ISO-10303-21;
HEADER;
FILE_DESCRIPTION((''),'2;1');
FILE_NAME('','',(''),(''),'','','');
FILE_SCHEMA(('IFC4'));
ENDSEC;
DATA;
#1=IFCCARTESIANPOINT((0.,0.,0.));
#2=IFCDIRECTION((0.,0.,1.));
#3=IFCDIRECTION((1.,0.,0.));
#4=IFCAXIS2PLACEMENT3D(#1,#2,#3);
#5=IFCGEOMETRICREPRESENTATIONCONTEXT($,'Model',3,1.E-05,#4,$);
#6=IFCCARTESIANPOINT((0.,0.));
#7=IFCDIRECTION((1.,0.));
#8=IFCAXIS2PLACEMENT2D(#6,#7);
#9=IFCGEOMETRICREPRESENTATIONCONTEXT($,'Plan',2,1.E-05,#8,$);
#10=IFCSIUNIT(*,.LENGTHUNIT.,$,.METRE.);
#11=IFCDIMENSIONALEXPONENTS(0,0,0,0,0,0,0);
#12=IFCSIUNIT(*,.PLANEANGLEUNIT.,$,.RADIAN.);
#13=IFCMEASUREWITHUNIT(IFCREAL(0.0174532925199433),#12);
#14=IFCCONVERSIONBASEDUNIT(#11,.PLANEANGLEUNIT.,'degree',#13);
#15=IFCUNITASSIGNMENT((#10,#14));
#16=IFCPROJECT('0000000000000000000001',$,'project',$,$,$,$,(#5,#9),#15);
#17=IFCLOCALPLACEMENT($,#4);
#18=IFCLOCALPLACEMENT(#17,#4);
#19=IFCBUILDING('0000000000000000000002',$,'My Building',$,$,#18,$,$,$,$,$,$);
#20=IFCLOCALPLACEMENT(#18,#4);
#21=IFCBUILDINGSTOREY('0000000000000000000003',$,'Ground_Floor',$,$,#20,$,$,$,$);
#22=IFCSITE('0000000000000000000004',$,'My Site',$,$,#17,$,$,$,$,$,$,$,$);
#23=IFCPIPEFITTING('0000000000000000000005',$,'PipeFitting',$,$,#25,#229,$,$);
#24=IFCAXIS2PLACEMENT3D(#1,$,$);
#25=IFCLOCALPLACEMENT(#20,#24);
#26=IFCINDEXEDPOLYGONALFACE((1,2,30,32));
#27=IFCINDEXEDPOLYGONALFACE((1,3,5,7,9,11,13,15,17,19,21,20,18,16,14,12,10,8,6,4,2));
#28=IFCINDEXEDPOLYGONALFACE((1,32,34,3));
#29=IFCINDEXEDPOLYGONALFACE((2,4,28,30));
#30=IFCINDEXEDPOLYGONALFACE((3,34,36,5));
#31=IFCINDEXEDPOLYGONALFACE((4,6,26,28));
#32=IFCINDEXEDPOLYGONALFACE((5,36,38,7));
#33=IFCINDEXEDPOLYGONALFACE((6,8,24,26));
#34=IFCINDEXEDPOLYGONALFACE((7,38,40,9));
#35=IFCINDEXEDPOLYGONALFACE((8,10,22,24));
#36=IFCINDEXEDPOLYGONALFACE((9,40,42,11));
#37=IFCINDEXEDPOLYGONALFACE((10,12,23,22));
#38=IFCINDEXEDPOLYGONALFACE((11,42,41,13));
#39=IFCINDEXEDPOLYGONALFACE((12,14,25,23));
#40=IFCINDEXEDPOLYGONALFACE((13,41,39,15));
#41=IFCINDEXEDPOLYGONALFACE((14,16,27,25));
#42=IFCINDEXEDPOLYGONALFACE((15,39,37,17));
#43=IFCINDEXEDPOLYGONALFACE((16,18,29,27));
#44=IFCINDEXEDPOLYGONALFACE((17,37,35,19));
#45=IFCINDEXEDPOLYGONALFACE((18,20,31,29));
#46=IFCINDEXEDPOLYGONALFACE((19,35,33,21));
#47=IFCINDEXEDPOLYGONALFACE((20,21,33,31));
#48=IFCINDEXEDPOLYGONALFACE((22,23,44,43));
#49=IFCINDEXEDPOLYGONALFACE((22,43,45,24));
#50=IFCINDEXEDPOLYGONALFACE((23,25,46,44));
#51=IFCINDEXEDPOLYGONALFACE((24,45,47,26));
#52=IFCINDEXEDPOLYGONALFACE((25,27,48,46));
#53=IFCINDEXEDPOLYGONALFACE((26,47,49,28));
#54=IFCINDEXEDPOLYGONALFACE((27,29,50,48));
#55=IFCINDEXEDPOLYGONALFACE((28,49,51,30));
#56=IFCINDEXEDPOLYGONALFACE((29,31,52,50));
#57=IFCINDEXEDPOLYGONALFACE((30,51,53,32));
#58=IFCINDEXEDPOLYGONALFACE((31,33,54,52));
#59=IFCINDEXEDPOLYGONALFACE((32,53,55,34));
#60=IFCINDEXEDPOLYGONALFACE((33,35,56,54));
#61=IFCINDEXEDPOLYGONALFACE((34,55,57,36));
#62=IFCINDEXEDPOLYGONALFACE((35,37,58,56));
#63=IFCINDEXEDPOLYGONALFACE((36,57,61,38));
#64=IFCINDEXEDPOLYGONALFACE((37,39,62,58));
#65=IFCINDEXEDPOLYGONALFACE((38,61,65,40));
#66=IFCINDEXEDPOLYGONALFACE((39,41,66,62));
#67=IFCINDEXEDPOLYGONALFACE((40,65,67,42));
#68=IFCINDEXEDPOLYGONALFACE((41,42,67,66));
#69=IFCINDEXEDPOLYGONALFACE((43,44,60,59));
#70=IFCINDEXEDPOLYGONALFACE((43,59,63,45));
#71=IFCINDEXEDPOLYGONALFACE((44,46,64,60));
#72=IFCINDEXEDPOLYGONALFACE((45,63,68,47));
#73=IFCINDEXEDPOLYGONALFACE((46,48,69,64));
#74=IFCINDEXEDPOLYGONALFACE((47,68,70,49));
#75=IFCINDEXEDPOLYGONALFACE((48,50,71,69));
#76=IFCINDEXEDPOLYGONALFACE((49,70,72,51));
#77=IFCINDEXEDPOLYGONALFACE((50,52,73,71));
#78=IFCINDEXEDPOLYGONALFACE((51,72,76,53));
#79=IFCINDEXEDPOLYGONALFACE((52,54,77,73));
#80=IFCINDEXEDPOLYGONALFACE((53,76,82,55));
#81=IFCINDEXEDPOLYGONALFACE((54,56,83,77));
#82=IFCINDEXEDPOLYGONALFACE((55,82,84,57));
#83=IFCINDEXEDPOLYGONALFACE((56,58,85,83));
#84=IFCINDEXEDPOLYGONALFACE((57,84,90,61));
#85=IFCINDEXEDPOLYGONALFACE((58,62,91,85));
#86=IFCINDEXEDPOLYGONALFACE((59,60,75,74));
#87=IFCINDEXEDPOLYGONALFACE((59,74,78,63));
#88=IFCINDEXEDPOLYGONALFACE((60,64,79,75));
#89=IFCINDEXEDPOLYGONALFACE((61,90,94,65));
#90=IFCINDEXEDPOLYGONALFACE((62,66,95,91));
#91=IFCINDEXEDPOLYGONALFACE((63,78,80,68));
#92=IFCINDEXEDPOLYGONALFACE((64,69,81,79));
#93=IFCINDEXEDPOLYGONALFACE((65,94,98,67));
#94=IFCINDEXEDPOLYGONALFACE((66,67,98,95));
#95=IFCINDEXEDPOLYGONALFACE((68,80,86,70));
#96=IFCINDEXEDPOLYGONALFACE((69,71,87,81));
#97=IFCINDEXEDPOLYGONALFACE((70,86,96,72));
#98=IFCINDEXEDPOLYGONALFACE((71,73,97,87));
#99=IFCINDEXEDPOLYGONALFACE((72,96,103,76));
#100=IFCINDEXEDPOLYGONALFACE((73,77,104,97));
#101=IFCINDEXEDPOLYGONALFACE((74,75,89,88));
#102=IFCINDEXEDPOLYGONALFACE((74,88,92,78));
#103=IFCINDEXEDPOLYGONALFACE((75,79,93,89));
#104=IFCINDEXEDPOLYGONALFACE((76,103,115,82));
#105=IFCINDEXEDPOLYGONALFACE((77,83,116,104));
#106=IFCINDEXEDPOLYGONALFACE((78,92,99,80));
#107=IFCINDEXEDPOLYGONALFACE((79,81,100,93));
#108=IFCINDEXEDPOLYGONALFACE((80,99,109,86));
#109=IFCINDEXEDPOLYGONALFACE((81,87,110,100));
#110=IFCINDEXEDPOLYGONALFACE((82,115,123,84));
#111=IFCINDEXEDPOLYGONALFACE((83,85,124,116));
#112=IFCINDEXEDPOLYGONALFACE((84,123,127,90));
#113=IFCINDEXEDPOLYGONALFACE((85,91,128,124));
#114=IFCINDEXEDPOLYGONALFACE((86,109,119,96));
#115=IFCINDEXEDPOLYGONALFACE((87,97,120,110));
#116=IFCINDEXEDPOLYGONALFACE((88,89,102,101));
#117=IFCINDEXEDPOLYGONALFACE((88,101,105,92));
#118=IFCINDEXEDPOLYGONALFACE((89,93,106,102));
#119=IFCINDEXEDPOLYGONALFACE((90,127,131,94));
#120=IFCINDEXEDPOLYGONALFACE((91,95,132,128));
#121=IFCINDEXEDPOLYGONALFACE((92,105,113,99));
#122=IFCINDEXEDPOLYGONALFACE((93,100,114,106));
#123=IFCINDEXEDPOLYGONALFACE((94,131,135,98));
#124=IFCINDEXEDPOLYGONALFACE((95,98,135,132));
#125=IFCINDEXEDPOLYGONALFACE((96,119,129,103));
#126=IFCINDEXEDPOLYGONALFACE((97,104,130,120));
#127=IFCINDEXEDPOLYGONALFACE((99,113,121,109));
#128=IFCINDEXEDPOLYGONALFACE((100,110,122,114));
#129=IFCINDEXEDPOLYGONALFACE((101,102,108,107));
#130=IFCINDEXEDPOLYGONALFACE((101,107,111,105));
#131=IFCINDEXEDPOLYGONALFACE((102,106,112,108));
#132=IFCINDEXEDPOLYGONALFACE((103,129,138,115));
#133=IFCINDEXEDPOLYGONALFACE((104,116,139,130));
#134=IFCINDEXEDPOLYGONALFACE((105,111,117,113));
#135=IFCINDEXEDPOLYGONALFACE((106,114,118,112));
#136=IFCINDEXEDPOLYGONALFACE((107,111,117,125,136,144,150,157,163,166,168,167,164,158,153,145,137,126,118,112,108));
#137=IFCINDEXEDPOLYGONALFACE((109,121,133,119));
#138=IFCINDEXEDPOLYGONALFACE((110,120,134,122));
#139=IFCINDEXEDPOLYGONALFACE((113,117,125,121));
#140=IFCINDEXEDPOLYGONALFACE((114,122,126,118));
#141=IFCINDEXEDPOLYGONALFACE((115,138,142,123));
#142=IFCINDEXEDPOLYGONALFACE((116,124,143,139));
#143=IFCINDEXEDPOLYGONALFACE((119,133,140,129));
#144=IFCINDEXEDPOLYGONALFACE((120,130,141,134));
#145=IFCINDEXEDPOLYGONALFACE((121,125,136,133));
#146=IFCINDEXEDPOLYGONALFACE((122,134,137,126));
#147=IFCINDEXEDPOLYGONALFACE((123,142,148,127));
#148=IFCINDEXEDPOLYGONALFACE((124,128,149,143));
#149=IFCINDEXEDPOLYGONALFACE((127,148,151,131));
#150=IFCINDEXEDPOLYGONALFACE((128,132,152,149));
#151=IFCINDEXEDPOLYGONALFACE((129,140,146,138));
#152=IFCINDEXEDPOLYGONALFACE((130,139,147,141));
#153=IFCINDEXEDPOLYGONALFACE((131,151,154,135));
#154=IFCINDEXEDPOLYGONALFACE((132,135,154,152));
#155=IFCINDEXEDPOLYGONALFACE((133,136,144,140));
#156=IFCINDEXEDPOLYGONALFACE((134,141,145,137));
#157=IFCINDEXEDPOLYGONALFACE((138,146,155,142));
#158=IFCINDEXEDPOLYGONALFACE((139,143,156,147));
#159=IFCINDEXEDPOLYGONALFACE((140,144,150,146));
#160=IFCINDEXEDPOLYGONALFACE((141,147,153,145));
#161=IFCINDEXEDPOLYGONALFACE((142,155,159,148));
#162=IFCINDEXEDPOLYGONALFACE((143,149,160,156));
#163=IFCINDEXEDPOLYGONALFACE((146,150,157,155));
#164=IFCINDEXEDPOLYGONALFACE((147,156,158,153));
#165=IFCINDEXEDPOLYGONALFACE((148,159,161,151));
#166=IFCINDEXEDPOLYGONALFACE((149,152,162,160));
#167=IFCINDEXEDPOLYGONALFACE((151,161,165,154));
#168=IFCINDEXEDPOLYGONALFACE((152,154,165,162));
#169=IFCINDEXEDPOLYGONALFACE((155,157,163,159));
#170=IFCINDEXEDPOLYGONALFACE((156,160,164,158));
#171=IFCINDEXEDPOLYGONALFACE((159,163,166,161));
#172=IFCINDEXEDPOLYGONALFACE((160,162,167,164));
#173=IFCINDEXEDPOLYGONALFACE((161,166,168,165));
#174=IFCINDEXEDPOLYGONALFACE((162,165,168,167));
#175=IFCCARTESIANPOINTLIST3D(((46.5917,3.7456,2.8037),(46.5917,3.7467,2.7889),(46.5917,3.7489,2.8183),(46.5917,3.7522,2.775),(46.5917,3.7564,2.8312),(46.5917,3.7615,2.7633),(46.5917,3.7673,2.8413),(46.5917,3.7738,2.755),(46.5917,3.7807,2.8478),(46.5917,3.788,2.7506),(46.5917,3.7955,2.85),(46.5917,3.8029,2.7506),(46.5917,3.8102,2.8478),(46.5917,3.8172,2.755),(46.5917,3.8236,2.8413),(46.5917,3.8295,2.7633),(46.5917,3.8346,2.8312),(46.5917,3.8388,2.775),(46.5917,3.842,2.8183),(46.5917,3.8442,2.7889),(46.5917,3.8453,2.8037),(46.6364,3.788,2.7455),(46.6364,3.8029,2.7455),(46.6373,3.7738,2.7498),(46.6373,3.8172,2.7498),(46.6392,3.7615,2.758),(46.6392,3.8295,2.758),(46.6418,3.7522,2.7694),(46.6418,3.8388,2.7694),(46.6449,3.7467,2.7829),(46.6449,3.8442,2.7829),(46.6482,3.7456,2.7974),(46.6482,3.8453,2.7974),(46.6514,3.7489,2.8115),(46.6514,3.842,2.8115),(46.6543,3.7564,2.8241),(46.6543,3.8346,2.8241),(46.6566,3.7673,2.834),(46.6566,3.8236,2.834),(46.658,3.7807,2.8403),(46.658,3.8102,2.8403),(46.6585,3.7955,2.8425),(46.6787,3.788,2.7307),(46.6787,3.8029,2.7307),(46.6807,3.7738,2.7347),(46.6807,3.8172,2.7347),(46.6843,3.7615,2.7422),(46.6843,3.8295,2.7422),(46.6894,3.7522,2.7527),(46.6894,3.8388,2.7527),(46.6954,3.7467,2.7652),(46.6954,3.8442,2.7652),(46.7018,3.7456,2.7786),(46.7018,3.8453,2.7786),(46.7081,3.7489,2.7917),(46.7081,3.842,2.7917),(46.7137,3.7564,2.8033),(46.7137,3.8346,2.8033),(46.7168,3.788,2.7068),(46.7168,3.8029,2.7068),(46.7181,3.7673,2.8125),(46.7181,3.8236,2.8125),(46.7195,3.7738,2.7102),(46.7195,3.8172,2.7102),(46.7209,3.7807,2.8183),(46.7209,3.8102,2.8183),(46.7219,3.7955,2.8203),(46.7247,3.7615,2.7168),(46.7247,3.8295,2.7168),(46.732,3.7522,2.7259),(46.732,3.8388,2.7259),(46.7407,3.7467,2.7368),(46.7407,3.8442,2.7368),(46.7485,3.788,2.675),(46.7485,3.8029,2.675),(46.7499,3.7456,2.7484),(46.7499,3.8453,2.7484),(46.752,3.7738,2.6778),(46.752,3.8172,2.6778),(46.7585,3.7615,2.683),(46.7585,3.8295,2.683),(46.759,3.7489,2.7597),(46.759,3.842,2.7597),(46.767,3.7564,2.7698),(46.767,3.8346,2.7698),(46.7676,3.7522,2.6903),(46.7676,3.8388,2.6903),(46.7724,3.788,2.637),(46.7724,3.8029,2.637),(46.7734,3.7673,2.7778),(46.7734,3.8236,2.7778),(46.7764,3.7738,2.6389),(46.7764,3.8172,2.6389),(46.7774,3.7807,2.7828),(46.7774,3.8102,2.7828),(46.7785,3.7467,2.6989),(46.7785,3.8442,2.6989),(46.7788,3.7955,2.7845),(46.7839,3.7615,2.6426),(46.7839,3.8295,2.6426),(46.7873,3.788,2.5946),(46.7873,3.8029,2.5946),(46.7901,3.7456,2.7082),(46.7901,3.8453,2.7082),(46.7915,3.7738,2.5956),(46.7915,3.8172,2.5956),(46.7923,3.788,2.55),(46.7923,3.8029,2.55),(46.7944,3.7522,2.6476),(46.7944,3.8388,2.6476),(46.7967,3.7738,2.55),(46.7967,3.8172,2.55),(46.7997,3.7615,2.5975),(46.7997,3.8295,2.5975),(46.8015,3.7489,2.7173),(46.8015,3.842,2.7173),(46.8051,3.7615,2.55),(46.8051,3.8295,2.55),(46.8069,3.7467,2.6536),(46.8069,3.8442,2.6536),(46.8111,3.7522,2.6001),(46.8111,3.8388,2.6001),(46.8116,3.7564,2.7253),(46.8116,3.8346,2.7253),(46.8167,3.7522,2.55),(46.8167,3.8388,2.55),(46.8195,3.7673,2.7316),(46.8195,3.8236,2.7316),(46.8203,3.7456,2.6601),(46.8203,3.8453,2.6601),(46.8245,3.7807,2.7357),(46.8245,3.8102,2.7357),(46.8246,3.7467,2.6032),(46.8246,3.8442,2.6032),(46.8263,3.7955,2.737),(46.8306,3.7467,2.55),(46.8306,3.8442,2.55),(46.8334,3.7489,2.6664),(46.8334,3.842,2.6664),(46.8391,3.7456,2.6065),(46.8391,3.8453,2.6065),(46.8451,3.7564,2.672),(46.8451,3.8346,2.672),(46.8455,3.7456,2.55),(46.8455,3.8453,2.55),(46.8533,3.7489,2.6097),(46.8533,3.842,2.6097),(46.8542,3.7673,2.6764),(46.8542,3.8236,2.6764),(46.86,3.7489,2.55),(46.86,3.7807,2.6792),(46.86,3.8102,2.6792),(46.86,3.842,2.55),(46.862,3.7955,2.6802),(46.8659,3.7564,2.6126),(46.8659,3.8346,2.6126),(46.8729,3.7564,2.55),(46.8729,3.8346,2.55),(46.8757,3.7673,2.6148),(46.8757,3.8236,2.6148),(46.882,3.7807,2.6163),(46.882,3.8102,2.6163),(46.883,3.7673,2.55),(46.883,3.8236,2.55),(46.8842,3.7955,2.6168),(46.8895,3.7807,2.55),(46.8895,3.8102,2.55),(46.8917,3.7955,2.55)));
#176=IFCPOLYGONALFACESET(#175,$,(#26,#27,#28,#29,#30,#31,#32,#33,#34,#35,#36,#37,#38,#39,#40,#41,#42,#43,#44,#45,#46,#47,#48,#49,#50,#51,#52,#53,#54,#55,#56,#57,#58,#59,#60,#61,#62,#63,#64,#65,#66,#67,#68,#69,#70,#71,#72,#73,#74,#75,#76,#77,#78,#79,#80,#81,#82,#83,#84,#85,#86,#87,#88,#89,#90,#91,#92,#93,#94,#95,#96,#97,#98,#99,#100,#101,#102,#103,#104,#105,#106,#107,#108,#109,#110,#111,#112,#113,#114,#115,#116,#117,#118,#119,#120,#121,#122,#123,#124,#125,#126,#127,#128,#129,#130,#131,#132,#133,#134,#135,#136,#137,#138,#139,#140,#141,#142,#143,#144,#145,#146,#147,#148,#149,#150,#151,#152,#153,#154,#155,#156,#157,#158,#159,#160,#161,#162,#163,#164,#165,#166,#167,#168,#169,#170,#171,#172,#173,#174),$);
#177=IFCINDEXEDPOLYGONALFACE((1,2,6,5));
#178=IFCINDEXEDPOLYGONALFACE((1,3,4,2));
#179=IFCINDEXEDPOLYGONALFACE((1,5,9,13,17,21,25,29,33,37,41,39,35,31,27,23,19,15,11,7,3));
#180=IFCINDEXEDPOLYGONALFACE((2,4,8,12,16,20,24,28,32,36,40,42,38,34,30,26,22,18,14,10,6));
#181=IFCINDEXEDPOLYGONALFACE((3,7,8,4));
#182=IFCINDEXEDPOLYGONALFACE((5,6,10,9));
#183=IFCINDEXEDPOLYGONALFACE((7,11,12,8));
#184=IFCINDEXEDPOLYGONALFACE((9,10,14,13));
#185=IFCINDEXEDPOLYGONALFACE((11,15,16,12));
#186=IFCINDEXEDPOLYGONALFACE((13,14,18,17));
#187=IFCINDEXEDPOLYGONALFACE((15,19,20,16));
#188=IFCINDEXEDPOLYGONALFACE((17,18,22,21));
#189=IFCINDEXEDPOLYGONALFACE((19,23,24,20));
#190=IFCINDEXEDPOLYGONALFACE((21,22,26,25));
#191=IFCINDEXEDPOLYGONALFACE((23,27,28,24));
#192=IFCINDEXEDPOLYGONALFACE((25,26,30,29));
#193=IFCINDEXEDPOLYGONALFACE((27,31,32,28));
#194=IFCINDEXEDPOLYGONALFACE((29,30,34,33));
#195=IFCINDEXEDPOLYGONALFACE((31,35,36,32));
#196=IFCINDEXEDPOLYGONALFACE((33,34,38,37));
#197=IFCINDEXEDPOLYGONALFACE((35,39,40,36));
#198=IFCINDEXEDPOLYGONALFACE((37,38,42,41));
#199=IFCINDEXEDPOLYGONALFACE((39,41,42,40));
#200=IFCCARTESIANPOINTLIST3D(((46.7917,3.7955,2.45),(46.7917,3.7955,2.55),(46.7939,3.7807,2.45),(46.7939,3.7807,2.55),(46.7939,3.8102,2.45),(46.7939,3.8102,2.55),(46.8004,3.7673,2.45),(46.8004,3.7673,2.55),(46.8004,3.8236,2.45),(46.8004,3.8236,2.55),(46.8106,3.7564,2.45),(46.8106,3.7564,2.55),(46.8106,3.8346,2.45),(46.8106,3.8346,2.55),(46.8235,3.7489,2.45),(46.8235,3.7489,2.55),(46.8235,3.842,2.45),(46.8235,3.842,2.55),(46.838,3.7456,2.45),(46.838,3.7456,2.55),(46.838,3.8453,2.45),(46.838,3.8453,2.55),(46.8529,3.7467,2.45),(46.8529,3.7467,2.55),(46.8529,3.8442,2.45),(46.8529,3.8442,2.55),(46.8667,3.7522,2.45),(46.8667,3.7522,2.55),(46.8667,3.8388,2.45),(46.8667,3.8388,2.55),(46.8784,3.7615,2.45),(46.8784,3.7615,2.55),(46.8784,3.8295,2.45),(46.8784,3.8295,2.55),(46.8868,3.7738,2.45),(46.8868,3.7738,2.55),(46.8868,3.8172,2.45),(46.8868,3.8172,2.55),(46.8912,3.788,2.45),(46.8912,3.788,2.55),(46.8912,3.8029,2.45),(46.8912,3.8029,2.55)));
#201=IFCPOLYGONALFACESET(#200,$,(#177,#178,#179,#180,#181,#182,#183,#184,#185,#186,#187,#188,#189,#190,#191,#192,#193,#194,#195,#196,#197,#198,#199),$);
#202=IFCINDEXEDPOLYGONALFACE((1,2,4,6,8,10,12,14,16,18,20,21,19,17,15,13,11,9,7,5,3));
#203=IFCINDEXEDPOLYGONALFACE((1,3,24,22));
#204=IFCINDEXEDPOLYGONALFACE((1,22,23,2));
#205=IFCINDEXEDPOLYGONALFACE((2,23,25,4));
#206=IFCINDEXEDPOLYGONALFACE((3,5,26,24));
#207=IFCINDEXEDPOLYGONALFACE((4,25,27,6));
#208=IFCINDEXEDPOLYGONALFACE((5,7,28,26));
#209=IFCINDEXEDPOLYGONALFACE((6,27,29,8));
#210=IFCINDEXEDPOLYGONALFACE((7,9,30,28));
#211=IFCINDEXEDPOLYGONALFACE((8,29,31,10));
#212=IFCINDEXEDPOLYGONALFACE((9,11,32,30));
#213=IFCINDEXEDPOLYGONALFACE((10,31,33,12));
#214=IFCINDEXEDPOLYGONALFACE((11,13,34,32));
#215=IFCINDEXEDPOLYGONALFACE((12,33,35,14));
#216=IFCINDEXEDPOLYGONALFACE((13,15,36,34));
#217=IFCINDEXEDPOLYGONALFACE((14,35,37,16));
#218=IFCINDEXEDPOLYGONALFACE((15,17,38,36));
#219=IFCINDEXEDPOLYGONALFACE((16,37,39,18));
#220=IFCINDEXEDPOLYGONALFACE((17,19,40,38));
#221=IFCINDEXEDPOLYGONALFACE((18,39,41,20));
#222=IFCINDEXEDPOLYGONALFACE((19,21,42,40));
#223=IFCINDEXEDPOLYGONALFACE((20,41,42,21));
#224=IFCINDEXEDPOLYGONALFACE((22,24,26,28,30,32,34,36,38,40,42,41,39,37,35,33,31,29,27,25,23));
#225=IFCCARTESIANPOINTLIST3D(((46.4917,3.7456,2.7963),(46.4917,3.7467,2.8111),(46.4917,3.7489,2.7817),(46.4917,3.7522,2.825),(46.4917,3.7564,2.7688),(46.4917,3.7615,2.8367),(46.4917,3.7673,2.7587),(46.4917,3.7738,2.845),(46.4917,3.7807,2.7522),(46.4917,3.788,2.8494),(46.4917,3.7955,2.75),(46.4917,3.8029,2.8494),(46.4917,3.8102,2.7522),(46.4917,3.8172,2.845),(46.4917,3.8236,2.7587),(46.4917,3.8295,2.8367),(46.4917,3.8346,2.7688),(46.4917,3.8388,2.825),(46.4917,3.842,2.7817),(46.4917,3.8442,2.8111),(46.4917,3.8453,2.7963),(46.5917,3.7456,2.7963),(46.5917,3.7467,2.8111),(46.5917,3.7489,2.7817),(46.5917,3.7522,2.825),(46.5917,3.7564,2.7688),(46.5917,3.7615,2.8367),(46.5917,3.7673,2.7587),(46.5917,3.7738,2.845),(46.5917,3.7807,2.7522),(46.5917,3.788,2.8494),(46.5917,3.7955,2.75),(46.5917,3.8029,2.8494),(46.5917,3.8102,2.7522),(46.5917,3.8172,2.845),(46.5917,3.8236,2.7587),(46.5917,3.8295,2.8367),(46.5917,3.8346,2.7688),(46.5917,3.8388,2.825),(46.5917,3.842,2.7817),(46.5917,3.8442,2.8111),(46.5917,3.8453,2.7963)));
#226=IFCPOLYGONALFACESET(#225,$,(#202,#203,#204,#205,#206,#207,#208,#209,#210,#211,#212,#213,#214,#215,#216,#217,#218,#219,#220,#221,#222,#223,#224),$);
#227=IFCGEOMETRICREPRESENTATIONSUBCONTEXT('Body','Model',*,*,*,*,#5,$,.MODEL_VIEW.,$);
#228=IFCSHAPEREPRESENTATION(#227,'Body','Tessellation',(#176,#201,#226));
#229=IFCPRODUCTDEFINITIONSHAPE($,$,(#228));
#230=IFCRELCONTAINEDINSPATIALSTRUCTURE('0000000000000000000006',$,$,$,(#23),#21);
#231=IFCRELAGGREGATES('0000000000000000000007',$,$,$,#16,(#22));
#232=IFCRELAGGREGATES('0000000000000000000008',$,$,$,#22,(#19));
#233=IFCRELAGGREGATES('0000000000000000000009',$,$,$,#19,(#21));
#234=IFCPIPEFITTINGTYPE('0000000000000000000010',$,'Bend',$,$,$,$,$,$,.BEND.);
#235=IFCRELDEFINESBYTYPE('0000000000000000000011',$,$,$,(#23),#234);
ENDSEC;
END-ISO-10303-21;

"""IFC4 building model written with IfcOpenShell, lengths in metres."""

from ifc_helpers import new_model, entity, si_unit, converted_unit, frame, origin_with_axes, origin_2d_with_axis, place, context, subcontext, project, spatial, circle, extrude, source, transform, mapped, type_object, type_shapes, element, save


model = new_model("IFC4")

# Units and contexts
model_context = context("Model", 3, precision=1e-05, world=origin_with_axes())
plan_context = context("Plan", 2, precision=1e-05, world=origin_2d_with_axis())
body_context = subcontext(model_context, "Body", "Model", "MODEL_VIEW")
ifc_project = project(units=[si_unit("LENGTHUNIT", "METRE"), converted_unit("PLANEANGLEUNIT", "degree", entity("IfcReal", 0.0174532925199433), si_unit("PLANEANGLEUNIT", "RADIAN"), dimensions=[0, 0, 0, 0, 0, 0, 0])], contexts=[model_context, plan_context])

# Site, building, storey
site_placement = place(None, origin_with_axes())
site = spatial("IfcSite", under=ifc_project, at=site_placement, Name="My Site")
building_placement = place(site_placement, origin_with_axes())
building = spatial("IfcBuilding", under=site, at=building_placement, Name="My Building")
storey_placement = place(building_placement, origin_with_axes())
storey = spatial("IfcBuildingStorey", under=building, at=storey_placement, Name="Ground_Floor")

# Pipe fitting
pipe_fitting_type = type_object("IfcPipeFittingType", Name="Bend", PredefinedType="BEND")
shared_shape_1 = source(origin_with_axes(), body_context, "Body", "SolidModel", [
    entity("IfcSweptDiskSolid", entity("IfcIndexedPolyCurve", entity("IfcCartesianPointList3D", [[0.0, 0.0, -0.1], [0.0732, 0.0, -0.2768], [0.25, 0.0, -0.35]]), [entity("IfcArcIndex", [1, 2, 3])]), 0.05),
    extrude(circle(Radius=0.05), origin_with_axes(), (0.0, 0.0, -1.0), 0.1),
    extrude(circle(Radius=0.05), frame((0.25, 0.0, -0.35), z_axis=(1.0, 0.0, 0.0), x_axis=(0.0, 0.0, 1.0)), (0.0, 0.0, 1.0), 0.1),
])
type_shapes(pipe_fitting_type, [shared_shape_1])
for number, where, z_axis, x_axis, name in (
    (1, (46.8417, 3.7955, 2.45), (0.0, 0.0, -1.0), (-1.0, 0.0, 0.0), "PipeFitting"),
):
    element("IfcPipeFitting", number, at=place(storey_placement, frame(where, z_axis=z_axis, x_axis=x_axis)), inside=storey, type_object=pipe_fitting_type, Name=name, context=body_context, shape_type="MappedRepresentation", body=[
        mapped(shared_shape_1, transform((0.0, 0.0, 0.0), x_axis=(1.0, 0.0, 0.0), y_axis=(0.0, 1.0, 0.0), z_axis=(0.0, 0.0, 1.0), scale=1.0)),
    ])

save(model, "model.ifc")
